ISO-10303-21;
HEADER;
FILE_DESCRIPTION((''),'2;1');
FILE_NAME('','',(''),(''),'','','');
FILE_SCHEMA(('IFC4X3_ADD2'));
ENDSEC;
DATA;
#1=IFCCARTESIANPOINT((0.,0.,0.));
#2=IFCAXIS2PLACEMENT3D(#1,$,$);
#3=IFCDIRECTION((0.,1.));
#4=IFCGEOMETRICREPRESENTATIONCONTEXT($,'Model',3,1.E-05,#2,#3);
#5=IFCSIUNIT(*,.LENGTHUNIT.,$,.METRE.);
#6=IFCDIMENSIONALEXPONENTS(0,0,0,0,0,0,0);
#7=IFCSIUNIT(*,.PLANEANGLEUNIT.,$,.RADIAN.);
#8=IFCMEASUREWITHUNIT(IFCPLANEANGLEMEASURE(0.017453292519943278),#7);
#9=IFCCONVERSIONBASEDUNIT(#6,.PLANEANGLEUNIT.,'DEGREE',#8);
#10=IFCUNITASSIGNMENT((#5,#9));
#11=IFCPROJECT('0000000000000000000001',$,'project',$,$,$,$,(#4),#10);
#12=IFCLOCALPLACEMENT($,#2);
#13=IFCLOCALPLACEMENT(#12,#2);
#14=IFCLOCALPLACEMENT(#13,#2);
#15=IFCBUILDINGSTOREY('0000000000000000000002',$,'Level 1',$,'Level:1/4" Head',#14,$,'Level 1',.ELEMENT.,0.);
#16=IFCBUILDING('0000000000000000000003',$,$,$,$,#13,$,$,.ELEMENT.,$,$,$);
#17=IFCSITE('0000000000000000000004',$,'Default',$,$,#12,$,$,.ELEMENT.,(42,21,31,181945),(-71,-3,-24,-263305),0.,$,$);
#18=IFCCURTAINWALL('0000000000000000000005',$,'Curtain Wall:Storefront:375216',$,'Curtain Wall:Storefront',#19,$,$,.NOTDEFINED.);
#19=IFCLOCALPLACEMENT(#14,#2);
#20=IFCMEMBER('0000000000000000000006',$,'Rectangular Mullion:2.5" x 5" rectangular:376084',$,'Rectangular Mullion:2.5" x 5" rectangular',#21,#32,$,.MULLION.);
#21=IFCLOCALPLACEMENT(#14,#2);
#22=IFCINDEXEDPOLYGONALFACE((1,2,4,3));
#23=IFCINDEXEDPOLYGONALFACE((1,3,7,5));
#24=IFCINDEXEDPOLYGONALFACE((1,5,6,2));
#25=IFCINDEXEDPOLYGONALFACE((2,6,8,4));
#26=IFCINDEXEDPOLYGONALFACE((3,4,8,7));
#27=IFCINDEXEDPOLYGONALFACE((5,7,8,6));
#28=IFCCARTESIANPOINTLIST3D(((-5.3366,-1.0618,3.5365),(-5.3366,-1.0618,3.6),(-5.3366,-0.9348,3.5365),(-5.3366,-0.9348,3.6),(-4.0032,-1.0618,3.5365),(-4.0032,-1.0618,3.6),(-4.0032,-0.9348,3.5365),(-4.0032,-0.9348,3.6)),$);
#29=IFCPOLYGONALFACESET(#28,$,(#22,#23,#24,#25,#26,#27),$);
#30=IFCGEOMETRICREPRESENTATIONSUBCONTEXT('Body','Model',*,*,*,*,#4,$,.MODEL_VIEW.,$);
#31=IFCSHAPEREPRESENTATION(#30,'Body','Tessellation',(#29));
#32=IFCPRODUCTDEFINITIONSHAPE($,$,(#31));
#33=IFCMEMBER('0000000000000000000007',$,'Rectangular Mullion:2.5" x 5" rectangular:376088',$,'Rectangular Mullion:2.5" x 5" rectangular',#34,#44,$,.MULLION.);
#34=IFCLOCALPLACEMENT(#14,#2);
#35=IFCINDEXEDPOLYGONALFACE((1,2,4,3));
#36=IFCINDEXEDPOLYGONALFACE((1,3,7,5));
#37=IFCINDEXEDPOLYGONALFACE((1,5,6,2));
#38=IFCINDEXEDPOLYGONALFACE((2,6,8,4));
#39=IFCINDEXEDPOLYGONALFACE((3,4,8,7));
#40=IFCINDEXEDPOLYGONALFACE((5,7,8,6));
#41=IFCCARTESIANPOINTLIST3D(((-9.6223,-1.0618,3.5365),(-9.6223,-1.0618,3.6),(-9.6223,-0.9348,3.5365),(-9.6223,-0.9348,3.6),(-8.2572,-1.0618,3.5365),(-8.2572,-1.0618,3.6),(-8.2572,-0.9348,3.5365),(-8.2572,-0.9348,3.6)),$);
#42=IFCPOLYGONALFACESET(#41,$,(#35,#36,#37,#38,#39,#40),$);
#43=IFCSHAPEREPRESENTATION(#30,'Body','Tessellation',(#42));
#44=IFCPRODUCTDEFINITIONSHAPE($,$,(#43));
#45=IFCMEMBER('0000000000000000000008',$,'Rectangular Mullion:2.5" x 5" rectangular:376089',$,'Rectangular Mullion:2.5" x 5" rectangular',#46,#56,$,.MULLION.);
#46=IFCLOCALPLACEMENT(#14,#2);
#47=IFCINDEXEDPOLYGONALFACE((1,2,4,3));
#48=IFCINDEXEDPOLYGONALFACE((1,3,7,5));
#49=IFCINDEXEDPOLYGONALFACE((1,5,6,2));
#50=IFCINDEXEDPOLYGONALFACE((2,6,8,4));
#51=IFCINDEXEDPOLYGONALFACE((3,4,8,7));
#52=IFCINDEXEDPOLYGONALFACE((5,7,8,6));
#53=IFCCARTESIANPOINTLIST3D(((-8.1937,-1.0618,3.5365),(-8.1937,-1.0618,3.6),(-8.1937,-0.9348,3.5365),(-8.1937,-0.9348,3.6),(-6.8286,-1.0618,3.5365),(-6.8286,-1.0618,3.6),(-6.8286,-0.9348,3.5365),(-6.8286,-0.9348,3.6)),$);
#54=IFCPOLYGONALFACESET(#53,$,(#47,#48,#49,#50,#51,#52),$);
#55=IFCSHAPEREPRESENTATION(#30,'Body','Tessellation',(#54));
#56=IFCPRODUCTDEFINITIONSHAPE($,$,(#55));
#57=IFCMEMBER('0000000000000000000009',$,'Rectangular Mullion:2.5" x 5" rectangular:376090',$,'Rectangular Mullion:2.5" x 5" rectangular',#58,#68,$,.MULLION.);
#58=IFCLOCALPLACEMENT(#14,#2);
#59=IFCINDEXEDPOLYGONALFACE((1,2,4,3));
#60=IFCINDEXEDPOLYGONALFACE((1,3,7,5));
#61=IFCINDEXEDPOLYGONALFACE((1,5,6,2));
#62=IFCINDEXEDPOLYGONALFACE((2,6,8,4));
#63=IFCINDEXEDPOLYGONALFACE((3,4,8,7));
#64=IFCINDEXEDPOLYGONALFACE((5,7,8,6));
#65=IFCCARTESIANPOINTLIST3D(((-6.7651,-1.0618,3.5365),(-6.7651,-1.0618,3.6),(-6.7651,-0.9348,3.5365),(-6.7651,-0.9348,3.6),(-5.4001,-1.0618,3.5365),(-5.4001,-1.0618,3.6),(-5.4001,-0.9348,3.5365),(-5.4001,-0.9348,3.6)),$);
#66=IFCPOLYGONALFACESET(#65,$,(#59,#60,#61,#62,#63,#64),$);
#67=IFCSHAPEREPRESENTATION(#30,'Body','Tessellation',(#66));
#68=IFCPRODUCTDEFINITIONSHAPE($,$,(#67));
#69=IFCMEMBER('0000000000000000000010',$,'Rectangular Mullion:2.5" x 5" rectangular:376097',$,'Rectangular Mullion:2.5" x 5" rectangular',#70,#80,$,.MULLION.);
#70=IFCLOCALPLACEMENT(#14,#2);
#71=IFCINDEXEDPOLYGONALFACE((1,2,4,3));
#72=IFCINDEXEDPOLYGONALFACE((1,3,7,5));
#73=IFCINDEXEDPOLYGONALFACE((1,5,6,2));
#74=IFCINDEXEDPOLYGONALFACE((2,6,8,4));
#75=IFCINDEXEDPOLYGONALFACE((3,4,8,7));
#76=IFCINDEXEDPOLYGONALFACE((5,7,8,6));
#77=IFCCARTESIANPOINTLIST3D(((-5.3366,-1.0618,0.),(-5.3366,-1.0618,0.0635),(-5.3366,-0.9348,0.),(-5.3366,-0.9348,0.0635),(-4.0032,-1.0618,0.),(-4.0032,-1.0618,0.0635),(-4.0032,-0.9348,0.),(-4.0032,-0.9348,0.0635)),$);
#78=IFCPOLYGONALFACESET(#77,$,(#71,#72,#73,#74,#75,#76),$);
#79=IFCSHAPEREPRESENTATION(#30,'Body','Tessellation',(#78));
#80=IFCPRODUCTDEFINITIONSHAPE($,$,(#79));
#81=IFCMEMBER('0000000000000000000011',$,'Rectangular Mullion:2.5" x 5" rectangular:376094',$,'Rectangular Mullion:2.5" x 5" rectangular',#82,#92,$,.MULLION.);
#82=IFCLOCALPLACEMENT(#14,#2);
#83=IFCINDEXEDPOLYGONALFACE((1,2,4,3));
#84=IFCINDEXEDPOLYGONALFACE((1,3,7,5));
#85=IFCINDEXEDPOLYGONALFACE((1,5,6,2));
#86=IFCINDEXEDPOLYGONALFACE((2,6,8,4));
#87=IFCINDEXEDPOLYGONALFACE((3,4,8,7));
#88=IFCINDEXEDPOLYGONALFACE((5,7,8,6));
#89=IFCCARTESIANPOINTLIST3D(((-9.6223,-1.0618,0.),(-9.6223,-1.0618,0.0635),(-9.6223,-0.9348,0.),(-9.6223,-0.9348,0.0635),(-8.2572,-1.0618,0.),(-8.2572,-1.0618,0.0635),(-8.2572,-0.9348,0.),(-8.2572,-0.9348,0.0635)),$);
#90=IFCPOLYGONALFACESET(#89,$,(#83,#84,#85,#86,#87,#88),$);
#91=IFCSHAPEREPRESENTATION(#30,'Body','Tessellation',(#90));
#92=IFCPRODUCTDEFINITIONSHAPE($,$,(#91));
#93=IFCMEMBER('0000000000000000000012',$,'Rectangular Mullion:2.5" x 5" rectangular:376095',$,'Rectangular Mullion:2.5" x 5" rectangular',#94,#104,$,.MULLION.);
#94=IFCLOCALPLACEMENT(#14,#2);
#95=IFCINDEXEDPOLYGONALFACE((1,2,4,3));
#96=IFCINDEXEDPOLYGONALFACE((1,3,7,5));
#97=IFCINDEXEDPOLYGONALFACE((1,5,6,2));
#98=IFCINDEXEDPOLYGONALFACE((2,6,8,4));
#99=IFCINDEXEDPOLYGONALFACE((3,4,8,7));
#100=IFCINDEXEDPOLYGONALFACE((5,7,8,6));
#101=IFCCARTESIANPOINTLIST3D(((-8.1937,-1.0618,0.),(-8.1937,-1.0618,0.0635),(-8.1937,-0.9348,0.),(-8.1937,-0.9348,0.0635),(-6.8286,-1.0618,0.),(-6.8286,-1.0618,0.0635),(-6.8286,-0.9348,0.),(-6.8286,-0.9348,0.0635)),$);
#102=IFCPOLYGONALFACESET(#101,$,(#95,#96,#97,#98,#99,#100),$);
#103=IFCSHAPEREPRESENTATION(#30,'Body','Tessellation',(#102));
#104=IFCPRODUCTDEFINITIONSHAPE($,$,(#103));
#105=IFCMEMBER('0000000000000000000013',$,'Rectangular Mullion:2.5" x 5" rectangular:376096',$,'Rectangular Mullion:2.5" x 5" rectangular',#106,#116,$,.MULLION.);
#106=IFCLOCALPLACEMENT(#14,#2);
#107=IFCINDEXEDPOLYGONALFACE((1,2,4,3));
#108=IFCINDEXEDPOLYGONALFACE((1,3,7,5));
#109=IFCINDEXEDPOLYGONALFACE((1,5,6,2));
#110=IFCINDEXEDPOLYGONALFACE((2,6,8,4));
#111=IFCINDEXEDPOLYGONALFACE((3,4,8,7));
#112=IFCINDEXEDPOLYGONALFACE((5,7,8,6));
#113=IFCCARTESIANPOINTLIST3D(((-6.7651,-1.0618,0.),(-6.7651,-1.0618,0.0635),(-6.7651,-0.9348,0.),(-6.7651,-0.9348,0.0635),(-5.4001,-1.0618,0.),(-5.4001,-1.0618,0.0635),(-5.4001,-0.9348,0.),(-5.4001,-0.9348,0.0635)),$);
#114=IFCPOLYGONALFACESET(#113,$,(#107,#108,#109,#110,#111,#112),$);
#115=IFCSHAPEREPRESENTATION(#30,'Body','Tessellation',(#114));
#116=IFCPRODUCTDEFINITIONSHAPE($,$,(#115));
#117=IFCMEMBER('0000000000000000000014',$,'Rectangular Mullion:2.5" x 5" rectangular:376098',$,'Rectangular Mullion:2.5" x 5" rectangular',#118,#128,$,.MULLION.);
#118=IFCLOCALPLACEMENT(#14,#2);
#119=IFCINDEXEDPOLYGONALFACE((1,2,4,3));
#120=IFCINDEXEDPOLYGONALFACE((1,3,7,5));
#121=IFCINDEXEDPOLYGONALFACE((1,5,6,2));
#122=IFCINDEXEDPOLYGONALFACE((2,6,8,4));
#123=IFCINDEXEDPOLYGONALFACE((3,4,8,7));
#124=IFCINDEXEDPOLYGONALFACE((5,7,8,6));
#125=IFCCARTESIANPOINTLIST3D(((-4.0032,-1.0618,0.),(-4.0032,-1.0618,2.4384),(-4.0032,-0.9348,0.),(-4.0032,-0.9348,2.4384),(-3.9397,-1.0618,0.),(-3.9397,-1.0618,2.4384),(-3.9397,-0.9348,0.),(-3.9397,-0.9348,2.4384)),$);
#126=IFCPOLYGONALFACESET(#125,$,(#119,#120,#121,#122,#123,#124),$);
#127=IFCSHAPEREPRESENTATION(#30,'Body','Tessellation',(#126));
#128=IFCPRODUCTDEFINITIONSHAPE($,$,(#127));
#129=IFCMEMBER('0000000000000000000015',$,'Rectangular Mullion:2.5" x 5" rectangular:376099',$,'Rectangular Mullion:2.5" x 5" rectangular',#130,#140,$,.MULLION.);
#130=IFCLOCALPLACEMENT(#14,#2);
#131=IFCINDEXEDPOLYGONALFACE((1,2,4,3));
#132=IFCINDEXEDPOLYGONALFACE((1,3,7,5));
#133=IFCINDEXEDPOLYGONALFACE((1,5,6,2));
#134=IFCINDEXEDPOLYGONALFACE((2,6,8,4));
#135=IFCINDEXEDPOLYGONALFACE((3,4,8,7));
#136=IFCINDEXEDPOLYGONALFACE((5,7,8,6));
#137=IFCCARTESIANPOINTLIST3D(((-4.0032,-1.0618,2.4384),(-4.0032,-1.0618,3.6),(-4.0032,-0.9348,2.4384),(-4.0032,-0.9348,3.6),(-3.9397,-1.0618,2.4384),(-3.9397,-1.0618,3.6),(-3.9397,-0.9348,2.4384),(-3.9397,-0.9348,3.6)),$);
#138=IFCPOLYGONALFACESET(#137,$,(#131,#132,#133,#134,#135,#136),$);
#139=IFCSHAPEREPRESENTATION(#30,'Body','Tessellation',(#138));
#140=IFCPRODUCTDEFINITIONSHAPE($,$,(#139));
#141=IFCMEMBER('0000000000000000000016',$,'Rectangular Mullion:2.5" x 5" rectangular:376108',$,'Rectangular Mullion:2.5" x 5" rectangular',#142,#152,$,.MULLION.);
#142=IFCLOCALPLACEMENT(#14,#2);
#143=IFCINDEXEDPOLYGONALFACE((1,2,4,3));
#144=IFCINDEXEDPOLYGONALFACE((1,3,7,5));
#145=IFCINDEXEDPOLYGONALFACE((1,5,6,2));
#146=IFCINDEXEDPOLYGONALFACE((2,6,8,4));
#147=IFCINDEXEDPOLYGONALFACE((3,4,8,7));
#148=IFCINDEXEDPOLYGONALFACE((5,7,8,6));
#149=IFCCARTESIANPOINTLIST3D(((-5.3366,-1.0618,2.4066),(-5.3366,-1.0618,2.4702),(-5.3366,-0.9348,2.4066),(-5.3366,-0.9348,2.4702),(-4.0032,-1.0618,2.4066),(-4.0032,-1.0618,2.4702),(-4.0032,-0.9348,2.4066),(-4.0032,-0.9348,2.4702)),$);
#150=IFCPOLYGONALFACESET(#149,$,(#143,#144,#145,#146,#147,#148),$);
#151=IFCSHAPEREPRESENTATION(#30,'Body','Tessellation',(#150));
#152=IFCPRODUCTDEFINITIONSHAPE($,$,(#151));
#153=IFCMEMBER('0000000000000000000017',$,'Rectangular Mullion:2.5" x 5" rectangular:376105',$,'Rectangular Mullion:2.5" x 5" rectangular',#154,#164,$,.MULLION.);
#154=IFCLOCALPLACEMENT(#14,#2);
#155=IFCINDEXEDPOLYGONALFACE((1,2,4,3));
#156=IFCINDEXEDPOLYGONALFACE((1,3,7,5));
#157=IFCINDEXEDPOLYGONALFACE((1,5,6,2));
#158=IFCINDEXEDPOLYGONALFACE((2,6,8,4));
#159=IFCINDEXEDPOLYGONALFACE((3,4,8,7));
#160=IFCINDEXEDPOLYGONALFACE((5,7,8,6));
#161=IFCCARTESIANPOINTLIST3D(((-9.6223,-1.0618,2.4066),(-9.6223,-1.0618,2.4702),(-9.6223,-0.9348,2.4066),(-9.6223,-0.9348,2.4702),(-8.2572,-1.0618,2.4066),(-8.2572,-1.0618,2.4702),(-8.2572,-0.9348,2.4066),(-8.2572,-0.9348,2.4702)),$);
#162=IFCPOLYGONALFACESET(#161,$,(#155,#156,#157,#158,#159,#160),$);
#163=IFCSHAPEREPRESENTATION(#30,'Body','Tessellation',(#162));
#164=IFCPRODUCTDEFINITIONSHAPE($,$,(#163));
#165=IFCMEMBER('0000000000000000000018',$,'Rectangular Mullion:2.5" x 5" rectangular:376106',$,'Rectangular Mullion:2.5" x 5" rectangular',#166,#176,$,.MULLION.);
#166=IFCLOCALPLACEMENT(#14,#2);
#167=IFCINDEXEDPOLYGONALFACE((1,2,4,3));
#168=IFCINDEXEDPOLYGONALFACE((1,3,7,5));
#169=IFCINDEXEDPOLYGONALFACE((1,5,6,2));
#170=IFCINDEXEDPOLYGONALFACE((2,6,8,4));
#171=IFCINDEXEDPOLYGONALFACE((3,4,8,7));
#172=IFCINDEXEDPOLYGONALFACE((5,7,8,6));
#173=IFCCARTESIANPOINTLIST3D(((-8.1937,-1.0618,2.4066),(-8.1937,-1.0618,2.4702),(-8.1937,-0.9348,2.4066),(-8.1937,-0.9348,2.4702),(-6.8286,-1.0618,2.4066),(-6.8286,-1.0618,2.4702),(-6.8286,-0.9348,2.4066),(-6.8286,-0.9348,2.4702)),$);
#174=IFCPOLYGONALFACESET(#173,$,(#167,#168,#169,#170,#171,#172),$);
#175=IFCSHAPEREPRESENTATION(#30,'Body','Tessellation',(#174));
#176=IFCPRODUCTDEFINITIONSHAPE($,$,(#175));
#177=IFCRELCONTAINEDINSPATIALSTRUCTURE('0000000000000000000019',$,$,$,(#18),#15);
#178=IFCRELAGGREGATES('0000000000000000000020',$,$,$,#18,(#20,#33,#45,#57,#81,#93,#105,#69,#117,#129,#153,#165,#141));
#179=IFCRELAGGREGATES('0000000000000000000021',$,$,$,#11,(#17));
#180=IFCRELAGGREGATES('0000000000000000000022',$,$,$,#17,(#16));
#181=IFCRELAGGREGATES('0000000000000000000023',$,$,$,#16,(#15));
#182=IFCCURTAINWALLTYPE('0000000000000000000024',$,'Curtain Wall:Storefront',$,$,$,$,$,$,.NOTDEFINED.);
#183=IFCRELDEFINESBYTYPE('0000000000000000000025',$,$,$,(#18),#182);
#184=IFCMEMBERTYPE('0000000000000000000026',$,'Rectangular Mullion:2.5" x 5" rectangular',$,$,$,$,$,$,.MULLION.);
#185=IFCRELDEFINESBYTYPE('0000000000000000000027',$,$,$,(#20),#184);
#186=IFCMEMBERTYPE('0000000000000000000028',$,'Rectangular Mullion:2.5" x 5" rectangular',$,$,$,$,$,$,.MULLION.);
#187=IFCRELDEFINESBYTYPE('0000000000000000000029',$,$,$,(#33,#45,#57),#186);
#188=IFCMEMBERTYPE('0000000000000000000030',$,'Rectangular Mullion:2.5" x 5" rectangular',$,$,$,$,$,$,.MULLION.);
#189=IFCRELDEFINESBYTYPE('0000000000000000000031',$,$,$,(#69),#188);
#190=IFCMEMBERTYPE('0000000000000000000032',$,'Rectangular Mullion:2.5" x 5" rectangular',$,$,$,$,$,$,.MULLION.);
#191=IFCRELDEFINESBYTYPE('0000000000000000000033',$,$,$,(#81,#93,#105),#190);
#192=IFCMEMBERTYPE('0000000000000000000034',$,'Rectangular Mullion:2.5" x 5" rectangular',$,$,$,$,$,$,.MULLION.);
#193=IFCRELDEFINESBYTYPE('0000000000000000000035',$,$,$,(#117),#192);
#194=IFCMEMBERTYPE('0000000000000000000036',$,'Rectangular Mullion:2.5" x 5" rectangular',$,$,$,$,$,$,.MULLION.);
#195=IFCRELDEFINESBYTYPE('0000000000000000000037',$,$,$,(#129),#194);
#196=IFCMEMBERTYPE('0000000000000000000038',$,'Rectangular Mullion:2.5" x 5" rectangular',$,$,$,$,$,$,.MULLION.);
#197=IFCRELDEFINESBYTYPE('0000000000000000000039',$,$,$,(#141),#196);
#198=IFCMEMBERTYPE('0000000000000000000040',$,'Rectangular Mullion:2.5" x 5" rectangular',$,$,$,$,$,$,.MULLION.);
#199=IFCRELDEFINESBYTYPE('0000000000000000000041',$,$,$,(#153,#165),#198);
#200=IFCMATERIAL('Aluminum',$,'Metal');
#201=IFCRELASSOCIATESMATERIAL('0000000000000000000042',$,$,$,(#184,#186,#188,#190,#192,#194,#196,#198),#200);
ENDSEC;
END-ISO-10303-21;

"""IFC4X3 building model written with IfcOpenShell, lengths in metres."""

from ifc_helpers import new_model, entity, si_unit, converted_unit, direction, frame, frame_2d, origin, origin_2d_with_axis, place, context, subcontext, project, spatial, rectangle, extrude, source, transform, mapped, material, material_profile, profile_set, type_object, type_shapes, element, aggregate, save


model = new_model("IFC4X3")

# Units and contexts
model_context = context("Model", 3, precision=1e-05, world=origin(), true_north=direction((0.0, 1.0)))
body_context = subcontext(model_context, "Body", "Model", "MODEL_VIEW")
ifc_project = project(units=[si_unit("LENGTHUNIT", "METRE"), converted_unit("PLANEANGLEUNIT", "DEGREE", entity("IfcPlaneAngleMeasure", 0.017453292519943278), si_unit("PLANEANGLEUNIT", "RADIAN"), dimensions=[0, 0, 0, 0, 0, 0, 0])], contexts=[model_context])

# Site, building, storey
site_placement = place(None, origin())
site = spatial("IfcSite", under=ifc_project, at=site_placement, Name="Default", CompositionType="ELEMENT", RefLatitude=(42, 21, 31, 181945), RefLongitude=(-71, -3, -24, -263305), RefElevation=0.0)
building_placement = place(site_placement, origin())
building = spatial("IfcBuilding", under=site, at=building_placement, CompositionType="ELEMENT")
storey_placement = place(building_placement, origin())
storey = spatial("IfcBuildingStorey", under=building, at=storey_placement, Name="Level 1", ObjectType="Level:1/4\" Head", LongName="Level 1", CompositionType="ELEMENT", Elevation=0.0)

# Curtain wall, members
curtain_wall_type = type_object("IfcCurtainWallType", Name="Curtain Wall:Storefront", PredefinedType="NOTDEFINED")
curtain_wall_placement = place(storey_placement, origin())
curtain_wall = element("IfcCurtainWall", 1, at=curtain_wall_placement, inside=storey, type_object=curtain_wall_type, Name="Curtain Wall:Storefront:375216", ObjectType="Curtain Wall:Storefront", PredefinedType="NOTDEFINED")
ifc_material_1 = material(Name="Aluminum", Category="Metal")
ifc_material_profile = material_profile(ifc_material_1, rectangle(XDim=0.0635, YDim=0.127, at=frame_2d((0.0, 0.0), x_axis=(1.0, 0.0))), Name="2.5\" x 5\" rectangular")
ifc_profile_set = profile_set([ifc_material_profile], Name="2.5\" x 5\" rectangular")
member_type_1 = type_object("IfcMemberType", Name="Rectangular Mullion:2.5\" x 5\" rectangular", PredefinedType="MULLION", material=ifc_profile_set)
shared_shape_1 = source(origin(), body_context, "Body", "SweptSolid", [
    extrude(rectangle(XDim=0.0635, YDim=0.127, at=frame_2d((0.0, 0.0), x_axis=(1.0, 0.0))), frame((-0.0318, 0.0, -1.3333), z_axis=(0.0, 0.0, 1.0), x_axis=(-1.0, 0.0, 0.0)), (0.0, 0.0, 1.0), 1.3333),
])
type_shapes(member_type_1, [shared_shape_1])
member_1_placement = place(curtain_wall_placement, frame((-4.0032, -0.9983, 3.6), z_axis=(1.0, 0.0, 0.0), x_axis=(0.0, 0.0, 1.0)))
member_1 = element("IfcMember", 2, at=member_1_placement, type_object=member_type_1, Name="Rectangular Mullion:2.5\" x 5\" rectangular:376084", ObjectType="Rectangular Mullion:2.5\" x 5\" rectangular", PredefinedType="MULLION", context=body_context, shape_type="MappedRepresentation", body=[
    mapped(shared_shape_1, transform((0.0, 0.0, 0.0), scale=1.0)),
])
member_type_2 = type_object("IfcMemberType", Name="Rectangular Mullion:2.5\" x 5\" rectangular", PredefinedType="MULLION", material=ifc_profile_set)
shared_shape_2 = source(origin(), body_context, "Body", "SweptSolid", [
    extrude(rectangle(XDim=0.0635, YDim=0.127, at=frame_2d((0.0, 0.0), x_axis=(1.0, 0.0))), frame((-0.0318, 0.0, -1.3651), z_axis=(0.0, 0.0, 1.0), x_axis=(-1.0, 0.0, 0.0)), (0.0, 0.0, 1.0), 1.3651),
])
type_shapes(member_type_2, [shared_shape_2])
member_2_placement = place(curtain_wall_placement, frame((-8.2572, -0.9983, 3.6), z_axis=(1.0, 0.0, 0.0), x_axis=(0.0, 0.0, 1.0)))
member_2 = element("IfcMember", 3, at=member_2_placement, type_object=member_type_2, Name="Rectangular Mullion:2.5\" x 5\" rectangular:376088", ObjectType="Rectangular Mullion:2.5\" x 5\" rectangular", PredefinedType="MULLION", context=body_context, shape_type="MappedRepresentation", body=[
    mapped(shared_shape_2, transform((0.0, 0.0, 0.0), scale=1.0)),
])
member_3_placement = place(curtain_wall_placement, frame((-6.8286, -0.9983, 3.6), z_axis=(1.0, 0.0, 0.0), x_axis=(0.0, 0.0, 1.0)))
member_3 = element("IfcMember", 4, at=member_3_placement, type_object=member_type_2, Name="Rectangular Mullion:2.5\" x 5\" rectangular:376089", ObjectType="Rectangular Mullion:2.5\" x 5\" rectangular", PredefinedType="MULLION", context=body_context, shape_type="MappedRepresentation", body=[
    mapped(shared_shape_2, transform((0.0, 0.0, 0.0), scale=1.0)),
])
member_4_placement = place(curtain_wall_placement, frame((-5.4001, -0.9983, 3.6), z_axis=(1.0, 0.0, 0.0), x_axis=(0.0, 0.0, 1.0)))
member_4 = element("IfcMember", 5, at=member_4_placement, type_object=member_type_2, Name="Rectangular Mullion:2.5\" x 5\" rectangular:376090", ObjectType="Rectangular Mullion:2.5\" x 5\" rectangular", PredefinedType="MULLION", context=body_context, shape_type="MappedRepresentation", body=[
    mapped(shared_shape_2, transform((0.0, 0.0, 0.0), scale=1.0)),
])
member_type_3 = type_object("IfcMemberType", Name="Rectangular Mullion:2.5\" x 5\" rectangular", PredefinedType="MULLION", material=ifc_profile_set)
shared_shape_3 = source(origin(), body_context, "Body", "SweptSolid", [
    extrude(rectangle(XDim=0.0635, YDim=0.127, at=frame_2d((0.0, 0.0), x_axis=(1.0, 0.0))), frame((-0.0318, 0.0, -1.3333), z_axis=(0.0, 0.0, 1.0), x_axis=(-1.0, 0.0, 0.0)), (0.0, 0.0, 1.0), 1.3333),
])
type_shapes(member_type_3, [shared_shape_3])
member_5_placement = place(curtain_wall_placement, frame((-5.3366, -0.9983, 0.0), z_axis=(-1.0, 0.0, 0.0), x_axis=(0.0, 0.0, -1.0)))
member_5 = element("IfcMember", 6, at=member_5_placement, type_object=member_type_3, Name="Rectangular Mullion:2.5\" x 5\" rectangular:376097", ObjectType="Rectangular Mullion:2.5\" x 5\" rectangular", PredefinedType="MULLION", context=body_context, shape_type="MappedRepresentation", body=[
    mapped(shared_shape_3, transform((0.0, 0.0, 0.0), scale=1.0)),
])
member_type_4 = type_object("IfcMemberType", Name="Rectangular Mullion:2.5\" x 5\" rectangular", PredefinedType="MULLION", material=ifc_profile_set)
shared_shape_4 = source(origin(), body_context, "Body", "SweptSolid", [
    extrude(rectangle(XDim=0.0635, YDim=0.127, at=frame_2d((0.0, 0.0), x_axis=(1.0, 0.0))), frame((-0.0318, 0.0, -1.3651), z_axis=(0.0, 0.0, 1.0), x_axis=(-1.0, 0.0, 0.0)), (0.0, 0.0, 1.0), 1.3651),
])
type_shapes(member_type_4, [shared_shape_4])
member_6_placement = place(curtain_wall_placement, frame((-9.6223, -0.9983, 0.0), z_axis=(-1.0, 0.0, 0.0), x_axis=(0.0, 0.0, -1.0)))
member_6 = element("IfcMember", 7, at=member_6_placement, type_object=member_type_4, Name="Rectangular Mullion:2.5\" x 5\" rectangular:376094", ObjectType="Rectangular Mullion:2.5\" x 5\" rectangular", PredefinedType="MULLION", context=body_context, shape_type="MappedRepresentation", body=[
    mapped(shared_shape_4, transform((0.0, 0.0, 0.0), scale=1.0)),
])
member_7_placement = place(curtain_wall_placement, frame((-8.1937, -0.9983, 0.0), z_axis=(-1.0, 0.0, 0.0), x_axis=(0.0, 0.0, -1.0)))
member_7 = element("IfcMember", 8, at=member_7_placement, type_object=member_type_4, Name="Rectangular Mullion:2.5\" x 5\" rectangular:376095", ObjectType="Rectangular Mullion:2.5\" x 5\" rectangular", PredefinedType="MULLION", context=body_context, shape_type="MappedRepresentation", body=[
    mapped(shared_shape_4, transform((0.0, 0.0, 0.0), scale=1.0)),
])
member_8_placement = place(curtain_wall_placement, frame((-6.7651, -0.9983, 0.0), z_axis=(-1.0, 0.0, 0.0), x_axis=(0.0, 0.0, -1.0)))
member_8 = element("IfcMember", 9, at=member_8_placement, type_object=member_type_4, Name="Rectangular Mullion:2.5\" x 5\" rectangular:376096", ObjectType="Rectangular Mullion:2.5\" x 5\" rectangular", PredefinedType="MULLION", context=body_context, shape_type="MappedRepresentation", body=[
    mapped(shared_shape_4, transform((0.0, 0.0, 0.0), scale=1.0)),
])
member_type_5 = type_object("IfcMemberType", Name="Rectangular Mullion:2.5\" x 5\" rectangular", PredefinedType="MULLION", material=ifc_profile_set)
shared_shape_5 = source(origin(), body_context, "Body", "SweptSolid", [
    extrude(rectangle(XDim=0.0635, YDim=0.127, at=origin_2d_with_axis()), frame((-0.0318, 0.0, -2.4384), z_axis=(0.0, 0.0, 1.0), x_axis=(-1.0, 0.0, 0.0)), (0.0, 0.0, 1.0), 2.4384),
])
type_shapes(member_type_5, [shared_shape_5])
member_9_placement = place(curtain_wall_placement, frame((-3.9397, -0.9983, 0.0), z_axis=(0.0, 0.0, -1.0), x_axis=(1.0, 0.0, 0.0)))
member_9 = element("IfcMember", 10, at=member_9_placement, type_object=member_type_5, Name="Rectangular Mullion:2.5\" x 5\" rectangular:376098", ObjectType="Rectangular Mullion:2.5\" x 5\" rectangular", PredefinedType="MULLION", context=body_context, shape_type="MappedRepresentation", body=[
    mapped(shared_shape_5, transform((0.0, 0.0, 0.0), scale=1.0)),
])
member_type_6 = type_object("IfcMemberType", Name="Rectangular Mullion:2.5\" x 5\" rectangular", PredefinedType="MULLION", material=ifc_profile_set)
shared_shape_6 = source(origin(), body_context, "Body", "SweptSolid", [
    extrude(rectangle(XDim=0.0635, YDim=0.127, at=origin_2d_with_axis()), frame((-0.0318, 0.0, -1.1616), z_axis=(0.0, 0.0, 1.0), x_axis=(-1.0, 0.0, 0.0)), (0.0, 0.0, 1.0), 1.1616),
])
type_shapes(member_type_6, [shared_shape_6])
member_10_placement = place(curtain_wall_placement, frame((-3.9397, -0.9983, 2.4384), z_axis=(0.0, 0.0, -1.0), x_axis=(1.0, 0.0, 0.0)))
member_10 = element("IfcMember", 11, at=member_10_placement, type_object=member_type_6, Name="Rectangular Mullion:2.5\" x 5\" rectangular:376099", ObjectType="Rectangular Mullion:2.5\" x 5\" rectangular", PredefinedType="MULLION", context=body_context, shape_type="MappedRepresentation", body=[
    mapped(shared_shape_6, transform((0.0, 0.0, 0.0), scale=1.0)),
])
member_type_7 = type_object("IfcMemberType", Name="Rectangular Mullion:2.5\" x 5\" rectangular", PredefinedType="MULLION", material=ifc_profile_set)
shared_shape_7 = source(origin(), body_context, "Body", "SweptSolid", [
    extrude(rectangle(XDim=0.0635, YDim=0.127, at=origin_2d_with_axis()), frame((0.0, 0.0, -1.3333), z_axis=(0.0, 0.0, 1.0), x_axis=(-1.0, 0.0, 0.0)), (0.0, 0.0, 1.0), 1.3333),
])
type_shapes(member_type_7, [shared_shape_7])
member_11_placement = place(curtain_wall_placement, frame((-4.0032, -0.9983, 2.4384), z_axis=(1.0, 0.0, 0.0), x_axis=(0.0, 0.0, 1.0)))
member_11 = element("IfcMember", 12, at=member_11_placement, type_object=member_type_7, Name="Rectangular Mullion:2.5\" x 5\" rectangular:376108", ObjectType="Rectangular Mullion:2.5\" x 5\" rectangular", PredefinedType="MULLION", context=body_context, shape_type="MappedRepresentation", body=[
    mapped(shared_shape_7, transform((0.0, 0.0, 0.0), scale=1.0)),
])
member_type_8 = type_object("IfcMemberType", Name="Rectangular Mullion:2.5\" x 5\" rectangular", PredefinedType="MULLION", material=ifc_profile_set)
shared_shape_8 = source(origin(), body_context, "Body", "SweptSolid", [
    extrude(rectangle(XDim=0.0635, YDim=0.127, at=origin_2d_with_axis()), frame((0.0, 0.0, -1.3651), z_axis=(0.0, 0.0, 1.0), x_axis=(-1.0, 0.0, 0.0)), (0.0, 0.0, 1.0), 1.3651),
])
type_shapes(member_type_8, [shared_shape_8])
member_12_placement = place(curtain_wall_placement, frame((-8.2572, -0.9983, 2.4384), z_axis=(1.0, 0.0, 0.0), x_axis=(0.0, 0.0, 1.0)))
member_12 = element("IfcMember", 13, at=member_12_placement, type_object=member_type_8, Name="Rectangular Mullion:2.5\" x 5\" rectangular:376105", ObjectType="Rectangular Mullion:2.5\" x 5\" rectangular", PredefinedType="MULLION", context=body_context, shape_type="MappedRepresentation", body=[
    mapped(shared_shape_8, transform((0.0, 0.0, 0.0), scale=1.0)),
])
member_13_placement = place(curtain_wall_placement, frame((-6.8286, -0.9983, 2.4384), z_axis=(1.0, 0.0, 0.0), x_axis=(0.0, 0.0, 1.0)))
member_13 = element("IfcMember", 14, at=member_13_placement, type_object=member_type_8, Name="Rectangular Mullion:2.5\" x 5\" rectangular:376106", ObjectType="Rectangular Mullion:2.5\" x 5\" rectangular", PredefinedType="MULLION", context=body_context, shape_type="MappedRepresentation", body=[
    mapped(shared_shape_8, transform((0.0, 0.0, 0.0), scale=1.0)),
])
aggregate(curtain_wall, [member_1, member_2, member_3, member_4, member_6, member_7, member_8, member_5, member_9, member_10, member_12, member_13, member_11])

save(model, "model.ifc")
